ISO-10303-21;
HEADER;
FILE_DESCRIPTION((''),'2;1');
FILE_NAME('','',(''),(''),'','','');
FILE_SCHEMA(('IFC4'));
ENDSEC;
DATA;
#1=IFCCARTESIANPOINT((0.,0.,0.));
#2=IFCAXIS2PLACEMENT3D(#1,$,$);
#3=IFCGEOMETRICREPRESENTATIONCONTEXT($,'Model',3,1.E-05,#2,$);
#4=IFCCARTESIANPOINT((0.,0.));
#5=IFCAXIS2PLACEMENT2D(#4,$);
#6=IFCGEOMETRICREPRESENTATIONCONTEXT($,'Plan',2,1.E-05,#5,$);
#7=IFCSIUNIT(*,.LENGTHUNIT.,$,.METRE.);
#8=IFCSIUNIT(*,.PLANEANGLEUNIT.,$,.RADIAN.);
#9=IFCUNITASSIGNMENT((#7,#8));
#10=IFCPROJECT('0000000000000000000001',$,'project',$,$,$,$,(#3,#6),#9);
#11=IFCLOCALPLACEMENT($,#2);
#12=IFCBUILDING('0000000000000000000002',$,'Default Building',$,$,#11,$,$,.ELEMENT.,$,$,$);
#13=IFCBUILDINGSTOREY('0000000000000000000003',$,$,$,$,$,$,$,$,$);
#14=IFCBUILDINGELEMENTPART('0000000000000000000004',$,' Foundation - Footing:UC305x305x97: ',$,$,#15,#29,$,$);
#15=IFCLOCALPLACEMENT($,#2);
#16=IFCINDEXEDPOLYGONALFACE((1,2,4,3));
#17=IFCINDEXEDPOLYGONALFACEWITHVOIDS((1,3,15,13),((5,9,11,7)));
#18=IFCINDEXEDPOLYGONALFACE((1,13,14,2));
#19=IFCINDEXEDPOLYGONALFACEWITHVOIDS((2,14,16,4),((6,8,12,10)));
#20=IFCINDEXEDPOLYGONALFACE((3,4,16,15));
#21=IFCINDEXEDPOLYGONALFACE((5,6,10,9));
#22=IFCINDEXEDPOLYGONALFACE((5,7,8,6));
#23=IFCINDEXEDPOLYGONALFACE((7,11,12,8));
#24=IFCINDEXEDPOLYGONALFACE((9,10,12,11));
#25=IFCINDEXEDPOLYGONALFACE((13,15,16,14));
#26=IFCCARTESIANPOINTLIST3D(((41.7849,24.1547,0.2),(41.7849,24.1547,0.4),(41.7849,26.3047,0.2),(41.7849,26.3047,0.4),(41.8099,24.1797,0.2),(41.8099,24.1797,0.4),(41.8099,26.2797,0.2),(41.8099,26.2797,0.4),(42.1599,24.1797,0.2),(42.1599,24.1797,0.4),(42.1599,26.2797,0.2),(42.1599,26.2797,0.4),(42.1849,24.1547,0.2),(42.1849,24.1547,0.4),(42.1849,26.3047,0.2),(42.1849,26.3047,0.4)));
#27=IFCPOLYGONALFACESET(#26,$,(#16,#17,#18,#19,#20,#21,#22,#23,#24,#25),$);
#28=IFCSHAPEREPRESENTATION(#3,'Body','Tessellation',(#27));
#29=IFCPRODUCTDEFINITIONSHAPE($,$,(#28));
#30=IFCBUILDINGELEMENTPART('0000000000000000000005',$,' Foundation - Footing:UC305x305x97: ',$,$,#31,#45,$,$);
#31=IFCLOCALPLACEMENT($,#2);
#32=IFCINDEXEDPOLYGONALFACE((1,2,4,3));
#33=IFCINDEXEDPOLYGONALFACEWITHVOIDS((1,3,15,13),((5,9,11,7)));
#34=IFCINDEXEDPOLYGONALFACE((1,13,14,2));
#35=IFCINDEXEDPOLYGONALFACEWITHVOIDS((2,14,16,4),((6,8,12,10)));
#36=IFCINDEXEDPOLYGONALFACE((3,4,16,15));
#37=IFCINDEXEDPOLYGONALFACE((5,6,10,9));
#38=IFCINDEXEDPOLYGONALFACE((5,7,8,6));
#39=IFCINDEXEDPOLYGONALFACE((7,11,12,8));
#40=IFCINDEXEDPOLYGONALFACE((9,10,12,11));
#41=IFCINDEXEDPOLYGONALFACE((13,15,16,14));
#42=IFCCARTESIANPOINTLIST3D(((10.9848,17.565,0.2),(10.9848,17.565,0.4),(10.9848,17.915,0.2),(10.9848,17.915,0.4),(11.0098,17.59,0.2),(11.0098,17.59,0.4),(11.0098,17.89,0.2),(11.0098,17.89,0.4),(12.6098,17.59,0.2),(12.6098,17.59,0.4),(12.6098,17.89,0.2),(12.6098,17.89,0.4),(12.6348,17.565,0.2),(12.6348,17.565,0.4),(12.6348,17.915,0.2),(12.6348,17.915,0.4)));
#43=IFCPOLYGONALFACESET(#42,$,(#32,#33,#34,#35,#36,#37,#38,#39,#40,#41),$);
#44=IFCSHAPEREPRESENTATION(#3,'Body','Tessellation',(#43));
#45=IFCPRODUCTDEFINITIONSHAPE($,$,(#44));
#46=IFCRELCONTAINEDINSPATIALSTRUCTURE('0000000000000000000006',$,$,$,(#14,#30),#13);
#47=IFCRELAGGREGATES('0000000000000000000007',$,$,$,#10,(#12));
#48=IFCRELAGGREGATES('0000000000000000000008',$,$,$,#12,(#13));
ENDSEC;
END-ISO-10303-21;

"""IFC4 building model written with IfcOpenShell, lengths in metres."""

from ifc_helpers import new_model, si_unit, origin, origin_2d, place, context, project, spatial, polyline, outline, extrude, element, save


model = new_model("IFC4")

# Units and contexts
model_context = context("Model", 3, precision=1e-05, world=origin())
plan_context = context("Plan", 2, precision=1e-05, world=origin_2d())
ifc_project = project(units=[si_unit("LENGTHUNIT", "METRE"), si_unit("PLANEANGLEUNIT", "RADIAN")], contexts=[model_context, plan_context])

# Building, storey
building_placement = place(None, origin())
building = spatial("IfcBuilding", under=ifc_project, at=building_placement, Name="Default Building", CompositionType="ELEMENT")
storey = spatial("IfcBuildingStorey", under=building)

# Building element parts, openings
building_element_part_1 = element("IfcBuildingElementPart", 1, inside=storey, Name=" Foundation - Footing:UC305x305x97: ", context=model_context, shape_type="SweptSolid", body=[
    extrude(outline(polyline([(41.7849, 26.3047, 0.2), (42.1849, 26.3047, 0.2), (42.1849, 24.1547, 0.2), (41.7849, 24.1547, 0.2), (41.7849, 26.3047, 0.2)])), None, (0.0, 0.0, 1.0), 0.2),
])
element("IfcOpeningElement", 2, inside=storey, cuts=building_element_part_1, context=model_context, shape_type="SweptSolid", body=[
    extrude(outline(polyline([(41.8099, 26.2797, 0.2), (42.1599, 26.2797, 0.2), (42.1599, 24.1797, 0.2), (41.8099, 24.1797, 0.2), (41.8099, 26.2797, 0.2)])), None, (0.0, 0.0, 1.0), 0.2),
])
building_element_part_2 = element("IfcBuildingElementPart", 3, inside=storey, Name=" Foundation - Footing:UC305x305x97: ", context=model_context, shape_type="SweptSolid", body=[
    extrude(outline(polyline([(10.9848, 17.565, 0.2), (10.9848, 17.915, 0.2), (12.6348, 17.915, 0.2), (12.6348, 17.565, 0.2), (10.9848, 17.565, 0.2)])), None, (0.0, 0.0, 1.0), 0.2),
])
element("IfcOpeningElement", 4, inside=storey, cuts=building_element_part_2, context=model_context, shape_type="SweptSolid", body=[
    extrude(outline(polyline([(11.0098, 17.59, 0.2), (11.0098, 17.89, 0.2), (12.6098, 17.89, 0.2), (12.6098, 17.59, 0.2), (11.0098, 17.59, 0.2)])), None, (0.0, 0.0, 1.0), 0.2),
])

save(model, "model.ifc")
